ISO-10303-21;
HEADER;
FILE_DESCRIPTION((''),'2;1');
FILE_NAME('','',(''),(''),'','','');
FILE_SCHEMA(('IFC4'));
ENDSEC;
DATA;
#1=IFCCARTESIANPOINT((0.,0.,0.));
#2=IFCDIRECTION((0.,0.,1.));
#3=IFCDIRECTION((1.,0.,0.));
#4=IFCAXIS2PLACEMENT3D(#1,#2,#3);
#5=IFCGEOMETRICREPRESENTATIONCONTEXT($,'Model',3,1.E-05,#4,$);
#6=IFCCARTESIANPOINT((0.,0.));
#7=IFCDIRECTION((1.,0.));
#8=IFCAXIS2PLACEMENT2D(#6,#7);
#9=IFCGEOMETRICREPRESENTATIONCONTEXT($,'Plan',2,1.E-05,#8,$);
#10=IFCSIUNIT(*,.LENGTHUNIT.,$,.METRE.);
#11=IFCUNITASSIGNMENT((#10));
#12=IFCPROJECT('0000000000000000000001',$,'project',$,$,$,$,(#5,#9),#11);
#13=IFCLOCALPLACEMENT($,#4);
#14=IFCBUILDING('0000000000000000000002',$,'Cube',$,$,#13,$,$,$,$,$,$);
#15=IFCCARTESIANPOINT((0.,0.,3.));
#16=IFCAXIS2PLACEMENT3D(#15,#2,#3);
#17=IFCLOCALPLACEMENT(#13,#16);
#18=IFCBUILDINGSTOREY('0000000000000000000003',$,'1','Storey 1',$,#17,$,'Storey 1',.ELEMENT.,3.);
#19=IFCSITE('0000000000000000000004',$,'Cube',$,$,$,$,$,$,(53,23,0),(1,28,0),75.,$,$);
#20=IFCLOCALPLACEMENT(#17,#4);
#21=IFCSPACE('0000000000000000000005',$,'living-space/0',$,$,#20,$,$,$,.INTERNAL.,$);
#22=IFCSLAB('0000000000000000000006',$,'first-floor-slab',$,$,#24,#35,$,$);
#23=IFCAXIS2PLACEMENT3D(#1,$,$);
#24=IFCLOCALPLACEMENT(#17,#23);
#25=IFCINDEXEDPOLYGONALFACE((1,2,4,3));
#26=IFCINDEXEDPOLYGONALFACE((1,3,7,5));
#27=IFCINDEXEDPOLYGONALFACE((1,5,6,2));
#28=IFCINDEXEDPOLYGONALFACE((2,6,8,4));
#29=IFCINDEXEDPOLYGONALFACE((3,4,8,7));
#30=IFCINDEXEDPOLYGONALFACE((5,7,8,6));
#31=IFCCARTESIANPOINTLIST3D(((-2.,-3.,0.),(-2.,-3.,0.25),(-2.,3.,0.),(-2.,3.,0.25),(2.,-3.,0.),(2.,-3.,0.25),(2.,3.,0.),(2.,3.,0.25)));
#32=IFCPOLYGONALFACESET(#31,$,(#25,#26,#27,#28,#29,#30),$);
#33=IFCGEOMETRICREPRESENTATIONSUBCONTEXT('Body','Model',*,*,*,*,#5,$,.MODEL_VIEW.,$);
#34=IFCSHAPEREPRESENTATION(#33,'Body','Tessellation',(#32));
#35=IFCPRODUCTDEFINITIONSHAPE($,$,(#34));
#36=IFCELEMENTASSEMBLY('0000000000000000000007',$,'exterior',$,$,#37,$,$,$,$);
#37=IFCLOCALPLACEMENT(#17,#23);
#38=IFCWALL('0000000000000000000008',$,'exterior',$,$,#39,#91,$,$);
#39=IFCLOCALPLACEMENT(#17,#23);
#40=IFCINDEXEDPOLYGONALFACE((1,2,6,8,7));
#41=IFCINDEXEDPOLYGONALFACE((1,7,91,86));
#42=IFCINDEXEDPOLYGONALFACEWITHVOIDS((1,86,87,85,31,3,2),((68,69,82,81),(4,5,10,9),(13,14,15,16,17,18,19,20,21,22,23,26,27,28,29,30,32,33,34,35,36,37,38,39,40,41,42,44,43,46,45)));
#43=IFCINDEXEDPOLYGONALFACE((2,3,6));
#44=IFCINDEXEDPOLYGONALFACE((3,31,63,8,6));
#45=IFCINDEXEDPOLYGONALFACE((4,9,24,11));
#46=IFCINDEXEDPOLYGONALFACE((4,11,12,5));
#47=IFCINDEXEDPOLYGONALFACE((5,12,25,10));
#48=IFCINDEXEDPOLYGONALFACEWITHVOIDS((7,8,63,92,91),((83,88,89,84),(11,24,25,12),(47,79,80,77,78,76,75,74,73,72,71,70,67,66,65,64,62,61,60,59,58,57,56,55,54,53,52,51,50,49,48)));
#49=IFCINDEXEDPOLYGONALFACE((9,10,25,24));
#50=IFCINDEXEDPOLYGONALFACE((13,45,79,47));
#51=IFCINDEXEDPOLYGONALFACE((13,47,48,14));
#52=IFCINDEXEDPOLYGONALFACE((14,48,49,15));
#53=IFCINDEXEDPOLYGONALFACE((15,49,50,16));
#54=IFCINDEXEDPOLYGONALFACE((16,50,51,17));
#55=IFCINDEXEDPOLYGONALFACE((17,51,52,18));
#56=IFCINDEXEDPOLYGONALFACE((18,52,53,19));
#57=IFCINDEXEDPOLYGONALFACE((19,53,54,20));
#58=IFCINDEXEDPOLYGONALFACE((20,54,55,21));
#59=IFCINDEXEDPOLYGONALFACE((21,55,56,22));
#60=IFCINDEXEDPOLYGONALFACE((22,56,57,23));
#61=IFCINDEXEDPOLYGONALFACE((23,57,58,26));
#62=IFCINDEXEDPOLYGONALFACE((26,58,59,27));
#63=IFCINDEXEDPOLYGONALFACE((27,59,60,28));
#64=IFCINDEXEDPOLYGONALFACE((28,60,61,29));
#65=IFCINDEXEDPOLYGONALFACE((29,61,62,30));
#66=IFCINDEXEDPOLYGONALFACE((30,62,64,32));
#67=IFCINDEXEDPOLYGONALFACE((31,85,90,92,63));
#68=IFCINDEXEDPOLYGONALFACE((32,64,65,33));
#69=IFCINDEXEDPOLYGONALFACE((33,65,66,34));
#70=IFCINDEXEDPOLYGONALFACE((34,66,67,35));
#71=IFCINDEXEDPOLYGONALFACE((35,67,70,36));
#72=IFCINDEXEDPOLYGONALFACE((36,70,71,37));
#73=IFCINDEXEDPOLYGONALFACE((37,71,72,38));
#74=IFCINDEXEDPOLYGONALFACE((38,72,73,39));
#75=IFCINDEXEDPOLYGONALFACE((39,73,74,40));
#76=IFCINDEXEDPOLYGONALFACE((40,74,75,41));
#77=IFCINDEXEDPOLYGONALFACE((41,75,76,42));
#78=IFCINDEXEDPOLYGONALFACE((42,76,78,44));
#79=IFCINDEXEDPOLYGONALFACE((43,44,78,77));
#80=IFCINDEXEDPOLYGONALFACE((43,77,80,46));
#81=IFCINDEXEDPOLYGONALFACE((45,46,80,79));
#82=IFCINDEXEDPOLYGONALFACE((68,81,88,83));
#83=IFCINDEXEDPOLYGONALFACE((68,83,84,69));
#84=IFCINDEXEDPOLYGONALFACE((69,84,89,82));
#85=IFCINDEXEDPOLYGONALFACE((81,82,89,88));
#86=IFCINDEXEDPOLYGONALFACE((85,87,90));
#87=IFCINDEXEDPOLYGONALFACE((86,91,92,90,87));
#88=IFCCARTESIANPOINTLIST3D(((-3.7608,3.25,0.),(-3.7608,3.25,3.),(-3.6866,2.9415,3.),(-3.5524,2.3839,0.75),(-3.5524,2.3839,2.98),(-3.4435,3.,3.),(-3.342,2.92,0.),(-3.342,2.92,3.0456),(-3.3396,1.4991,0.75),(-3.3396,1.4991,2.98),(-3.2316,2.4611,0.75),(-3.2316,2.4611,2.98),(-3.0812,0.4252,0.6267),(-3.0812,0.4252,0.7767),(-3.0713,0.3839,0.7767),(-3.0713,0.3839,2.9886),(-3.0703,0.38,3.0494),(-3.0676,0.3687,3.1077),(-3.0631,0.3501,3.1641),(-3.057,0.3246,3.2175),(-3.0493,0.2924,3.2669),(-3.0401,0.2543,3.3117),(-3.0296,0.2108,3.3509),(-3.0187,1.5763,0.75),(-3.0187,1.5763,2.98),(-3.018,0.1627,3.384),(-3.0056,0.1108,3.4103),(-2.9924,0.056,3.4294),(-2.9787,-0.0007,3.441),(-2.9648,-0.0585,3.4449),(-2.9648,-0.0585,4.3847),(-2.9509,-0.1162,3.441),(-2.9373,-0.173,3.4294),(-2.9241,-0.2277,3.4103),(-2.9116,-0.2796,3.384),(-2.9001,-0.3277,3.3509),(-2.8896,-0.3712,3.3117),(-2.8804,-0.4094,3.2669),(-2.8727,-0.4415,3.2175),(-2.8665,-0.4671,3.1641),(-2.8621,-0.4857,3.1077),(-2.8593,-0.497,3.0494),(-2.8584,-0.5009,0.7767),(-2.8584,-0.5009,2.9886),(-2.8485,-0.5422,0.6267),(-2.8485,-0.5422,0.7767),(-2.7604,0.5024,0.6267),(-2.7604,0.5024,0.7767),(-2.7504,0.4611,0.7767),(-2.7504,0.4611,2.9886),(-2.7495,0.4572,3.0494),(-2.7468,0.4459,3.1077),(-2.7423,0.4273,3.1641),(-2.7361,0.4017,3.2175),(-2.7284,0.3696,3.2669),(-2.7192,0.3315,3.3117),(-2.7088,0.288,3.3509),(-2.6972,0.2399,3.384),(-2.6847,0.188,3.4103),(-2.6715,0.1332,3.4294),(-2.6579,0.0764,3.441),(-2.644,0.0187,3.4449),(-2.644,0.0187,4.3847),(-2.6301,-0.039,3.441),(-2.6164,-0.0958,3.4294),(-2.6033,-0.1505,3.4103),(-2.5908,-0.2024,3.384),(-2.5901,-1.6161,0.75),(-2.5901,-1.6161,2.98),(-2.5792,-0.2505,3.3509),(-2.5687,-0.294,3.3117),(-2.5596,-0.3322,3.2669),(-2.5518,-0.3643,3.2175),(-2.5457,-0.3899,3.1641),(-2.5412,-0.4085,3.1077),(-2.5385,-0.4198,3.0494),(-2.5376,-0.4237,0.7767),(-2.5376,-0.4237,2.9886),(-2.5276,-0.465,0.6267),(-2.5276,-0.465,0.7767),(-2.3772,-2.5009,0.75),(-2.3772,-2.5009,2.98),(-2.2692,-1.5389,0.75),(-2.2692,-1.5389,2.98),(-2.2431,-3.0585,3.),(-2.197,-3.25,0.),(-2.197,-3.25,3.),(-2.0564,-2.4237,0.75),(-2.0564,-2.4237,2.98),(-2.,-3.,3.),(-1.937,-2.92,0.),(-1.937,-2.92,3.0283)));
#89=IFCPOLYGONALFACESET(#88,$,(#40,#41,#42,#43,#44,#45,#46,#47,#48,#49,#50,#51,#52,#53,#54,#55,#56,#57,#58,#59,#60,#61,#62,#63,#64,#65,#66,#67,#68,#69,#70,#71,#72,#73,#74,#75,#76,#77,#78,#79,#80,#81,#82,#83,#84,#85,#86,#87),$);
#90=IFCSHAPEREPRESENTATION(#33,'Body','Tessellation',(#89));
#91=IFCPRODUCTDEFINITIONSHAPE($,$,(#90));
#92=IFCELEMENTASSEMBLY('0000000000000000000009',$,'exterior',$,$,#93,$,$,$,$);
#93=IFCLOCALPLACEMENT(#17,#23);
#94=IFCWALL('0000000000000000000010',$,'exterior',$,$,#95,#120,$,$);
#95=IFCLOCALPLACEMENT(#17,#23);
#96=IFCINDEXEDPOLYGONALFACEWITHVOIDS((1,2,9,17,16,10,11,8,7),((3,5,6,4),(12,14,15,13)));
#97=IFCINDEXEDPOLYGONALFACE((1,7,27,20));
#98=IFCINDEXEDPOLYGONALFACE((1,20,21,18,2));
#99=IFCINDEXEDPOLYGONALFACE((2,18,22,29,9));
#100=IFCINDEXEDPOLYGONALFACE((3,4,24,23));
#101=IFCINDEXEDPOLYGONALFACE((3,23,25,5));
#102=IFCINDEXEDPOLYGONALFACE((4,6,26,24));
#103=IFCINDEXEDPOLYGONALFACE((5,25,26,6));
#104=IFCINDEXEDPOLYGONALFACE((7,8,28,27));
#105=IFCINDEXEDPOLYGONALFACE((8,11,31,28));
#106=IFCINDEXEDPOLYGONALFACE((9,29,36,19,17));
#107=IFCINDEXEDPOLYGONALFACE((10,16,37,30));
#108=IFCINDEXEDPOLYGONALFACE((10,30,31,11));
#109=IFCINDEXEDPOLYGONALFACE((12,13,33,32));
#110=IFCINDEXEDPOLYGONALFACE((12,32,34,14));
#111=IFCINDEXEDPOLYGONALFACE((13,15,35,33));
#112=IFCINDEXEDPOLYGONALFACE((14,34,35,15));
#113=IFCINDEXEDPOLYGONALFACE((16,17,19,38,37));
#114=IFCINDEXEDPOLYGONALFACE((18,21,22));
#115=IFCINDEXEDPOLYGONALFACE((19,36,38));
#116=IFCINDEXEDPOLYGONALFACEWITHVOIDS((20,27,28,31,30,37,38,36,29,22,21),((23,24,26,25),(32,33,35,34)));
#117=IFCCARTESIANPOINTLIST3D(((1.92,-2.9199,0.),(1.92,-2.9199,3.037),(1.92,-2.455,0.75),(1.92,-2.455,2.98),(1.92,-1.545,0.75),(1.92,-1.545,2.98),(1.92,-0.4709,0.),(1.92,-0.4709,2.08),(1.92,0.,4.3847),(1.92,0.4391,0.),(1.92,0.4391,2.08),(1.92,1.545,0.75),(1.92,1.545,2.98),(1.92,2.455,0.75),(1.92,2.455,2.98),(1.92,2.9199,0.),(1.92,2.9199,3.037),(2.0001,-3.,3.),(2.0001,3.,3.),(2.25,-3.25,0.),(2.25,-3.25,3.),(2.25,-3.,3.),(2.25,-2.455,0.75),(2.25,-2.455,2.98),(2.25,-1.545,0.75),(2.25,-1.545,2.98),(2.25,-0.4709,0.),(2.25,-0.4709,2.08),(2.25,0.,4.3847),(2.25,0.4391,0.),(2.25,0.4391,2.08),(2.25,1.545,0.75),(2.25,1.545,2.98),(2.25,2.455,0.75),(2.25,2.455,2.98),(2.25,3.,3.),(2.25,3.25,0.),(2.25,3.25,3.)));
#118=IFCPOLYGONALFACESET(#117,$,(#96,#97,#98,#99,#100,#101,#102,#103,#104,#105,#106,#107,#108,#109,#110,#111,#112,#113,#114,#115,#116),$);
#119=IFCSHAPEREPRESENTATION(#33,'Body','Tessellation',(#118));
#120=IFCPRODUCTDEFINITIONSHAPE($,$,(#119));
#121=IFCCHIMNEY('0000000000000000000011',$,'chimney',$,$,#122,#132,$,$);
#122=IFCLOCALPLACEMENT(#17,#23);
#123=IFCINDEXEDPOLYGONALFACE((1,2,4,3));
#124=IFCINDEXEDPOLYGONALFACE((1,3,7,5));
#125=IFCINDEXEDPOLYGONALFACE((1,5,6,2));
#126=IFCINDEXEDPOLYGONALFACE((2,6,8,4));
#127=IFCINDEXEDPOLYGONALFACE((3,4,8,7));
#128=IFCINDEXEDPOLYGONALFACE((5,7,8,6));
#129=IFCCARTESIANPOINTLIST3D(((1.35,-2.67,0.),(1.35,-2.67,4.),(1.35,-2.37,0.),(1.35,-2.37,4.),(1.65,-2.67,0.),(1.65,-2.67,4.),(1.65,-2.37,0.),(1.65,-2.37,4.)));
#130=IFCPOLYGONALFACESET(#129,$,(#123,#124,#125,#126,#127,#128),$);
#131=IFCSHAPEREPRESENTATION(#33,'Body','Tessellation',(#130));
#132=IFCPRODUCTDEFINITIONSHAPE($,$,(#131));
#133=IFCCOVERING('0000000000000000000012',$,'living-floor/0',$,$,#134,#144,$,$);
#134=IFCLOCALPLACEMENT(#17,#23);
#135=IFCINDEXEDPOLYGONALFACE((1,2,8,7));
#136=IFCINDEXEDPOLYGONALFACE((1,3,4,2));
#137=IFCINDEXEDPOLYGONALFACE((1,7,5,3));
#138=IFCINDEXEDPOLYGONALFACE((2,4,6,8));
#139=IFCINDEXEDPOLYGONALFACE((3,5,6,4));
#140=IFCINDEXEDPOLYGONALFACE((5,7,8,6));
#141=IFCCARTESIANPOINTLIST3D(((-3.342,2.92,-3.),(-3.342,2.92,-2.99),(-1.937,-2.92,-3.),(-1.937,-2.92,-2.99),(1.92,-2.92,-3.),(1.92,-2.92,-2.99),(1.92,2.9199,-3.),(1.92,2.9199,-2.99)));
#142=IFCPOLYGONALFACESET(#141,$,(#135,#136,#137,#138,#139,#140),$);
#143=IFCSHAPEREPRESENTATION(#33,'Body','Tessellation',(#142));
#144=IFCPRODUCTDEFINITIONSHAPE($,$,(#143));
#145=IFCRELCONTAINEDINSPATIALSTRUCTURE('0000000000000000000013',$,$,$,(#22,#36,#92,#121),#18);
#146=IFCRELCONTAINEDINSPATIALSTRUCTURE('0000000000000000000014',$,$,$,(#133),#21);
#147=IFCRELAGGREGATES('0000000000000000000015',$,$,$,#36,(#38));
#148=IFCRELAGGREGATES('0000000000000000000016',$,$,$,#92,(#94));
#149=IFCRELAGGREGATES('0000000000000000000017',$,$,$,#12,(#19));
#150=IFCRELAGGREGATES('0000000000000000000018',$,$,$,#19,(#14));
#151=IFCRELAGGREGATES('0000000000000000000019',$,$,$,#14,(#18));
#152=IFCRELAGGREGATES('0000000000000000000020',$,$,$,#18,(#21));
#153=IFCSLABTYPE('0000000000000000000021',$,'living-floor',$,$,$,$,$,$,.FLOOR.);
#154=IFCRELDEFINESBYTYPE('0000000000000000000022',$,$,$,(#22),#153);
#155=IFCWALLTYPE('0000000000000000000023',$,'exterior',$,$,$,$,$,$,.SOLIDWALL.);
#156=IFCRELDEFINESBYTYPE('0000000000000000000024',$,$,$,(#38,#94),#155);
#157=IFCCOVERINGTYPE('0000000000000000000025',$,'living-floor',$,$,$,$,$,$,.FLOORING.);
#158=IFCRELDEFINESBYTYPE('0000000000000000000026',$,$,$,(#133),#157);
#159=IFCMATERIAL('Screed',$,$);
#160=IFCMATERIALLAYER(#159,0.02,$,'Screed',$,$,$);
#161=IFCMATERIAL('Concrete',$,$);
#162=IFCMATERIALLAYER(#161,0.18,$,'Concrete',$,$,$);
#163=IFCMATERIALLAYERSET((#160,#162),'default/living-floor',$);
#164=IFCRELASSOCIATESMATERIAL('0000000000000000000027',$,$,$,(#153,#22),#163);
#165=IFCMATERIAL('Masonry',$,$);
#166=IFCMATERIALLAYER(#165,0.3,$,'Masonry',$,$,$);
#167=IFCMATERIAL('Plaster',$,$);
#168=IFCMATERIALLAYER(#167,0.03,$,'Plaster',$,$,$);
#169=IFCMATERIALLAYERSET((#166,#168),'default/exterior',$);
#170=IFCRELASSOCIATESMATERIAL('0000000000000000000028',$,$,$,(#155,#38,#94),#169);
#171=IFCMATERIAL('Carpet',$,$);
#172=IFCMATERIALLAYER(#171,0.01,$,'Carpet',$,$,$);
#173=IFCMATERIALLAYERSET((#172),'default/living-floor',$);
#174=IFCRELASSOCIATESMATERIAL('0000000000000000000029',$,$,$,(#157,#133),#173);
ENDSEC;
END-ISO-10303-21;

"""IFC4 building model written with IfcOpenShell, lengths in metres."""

from ifc_helpers import new_model, si_unit, frame, origin, origin_with_axes, origin_2d_with_axis, place, context, subcontext, project, spatial, polyline, line, indexed_curve, outline, extrude, clip, bounded_halfspace, source, transform, mapped, material, layer, layer_set, layer_usage, type_object, element, aggregate, save


model = new_model("IFC4")

# Units and contexts
model_context = context("Model", 3, precision=1e-05, world=origin_with_axes())
plan_context = context("Plan", 2, precision=1e-05, world=origin_2d_with_axis())
body_context_1 = subcontext(model_context, "Body", "Model", "MODEL_VIEW")
ifc_project = project(units=[si_unit("LENGTHUNIT", "METRE")], contexts=[model_context, plan_context])

# Site, building, storey
site = spatial("IfcSite", under=ifc_project, Name="Cube", RefLatitude=(53, 23, 0), RefLongitude=(1, 28, 0), RefElevation=75.0)
building_placement = place(None, origin_with_axes())
building = spatial("IfcBuilding", under=site, at=building_placement, Name="Cube")
storey_placement = place(building_placement, frame((0.0, 0.0, 3.0), z_axis=(0.0, 0.0, 1.0), x_axis=(1.0, 0.0, 0.0)))
storey = spatial("IfcBuildingStorey", under=building, at=storey_placement, Name="1", Description="Storey 1", LongName="Storey 1", CompositionType="ELEMENT", Elevation=3.0)

# Slab
ifc_material_1 = material(Name="Screed")
ifc_layer_1 = layer(ifc_material_1, 0.02, Name="Screed")
ifc_material_2 = material(Name="Concrete")
ifc_layer_2 = layer(ifc_material_2, 0.18, Name="Concrete")
ifc_layer_set_1 = layer_set([ifc_layer_1, ifc_layer_2], Name="default/living-floor")
ifc_layer_usage_1 = layer_usage(ifc_layer_set_1, "AXIS3", "POSITIVE", 0.0)
slab_type = type_object("IfcSlabType", Name="living-floor", PredefinedType="FLOOR", material=ifc_layer_set_1)
slab_placement = place(storey_placement, frame((-2.0, -3.0, 0.0), z_axis=(0.0, 0.0, 1.0), x_axis=(1.0, 0.0, 0.0)))
element("IfcSlab", 1, at=slab_placement, inside=storey, type_object=slab_type, material=ifc_layer_usage_1, Name="first-floor-slab", context=body_context_1, shape_type="SweptSolid", body=[
    extrude(outline(indexed_curve([(0.0, 0.0), (4.0, 0.0), (4.0, 6.0), (0.0, 6.0)])), None, (0.0, 0.0, 1.0), 0.25),
])

# Element assemblies, walls, openings
assembly_1_placement = place(storey_placement, frame((-3.4435, 3.0, 0.0), z_axis=(0.0, 0.0, 1.0), x_axis=(0.233915, -0.972257, 0.0)))
assembly_1 = element("IfcElementAssembly", 2, at=assembly_1_placement, inside=storey, Name="exterior")
ifc_material_3 = material(Name="Masonry")
ifc_layer_3 = layer(ifc_material_3, 0.3, Name="Masonry")
ifc_material_4 = material(Name="Plaster")
ifc_layer_4 = layer(ifc_material_4, 0.03, Name="Plaster")
ifc_layer_set_2 = layer_set([ifc_layer_3, ifc_layer_4], Name="default/exterior")
ifc_layer_usage_2 = layer_usage(ifc_layer_set_2, "AXIS2", "POSITIVE", -0.25)
wall_type = type_object("IfcWallType", Name="exterior", PredefinedType="SOLIDWALL", material=ifc_layer_set_2)
wall_1_placement = place(assembly_1_placement, frame((0.0, 0.0, 0.0), z_axis=(0.0, 0.0, 1.0), x_axis=(1.0, 0.0, 0.0)))
wall_1 = element("IfcWall", 3, at=wall_1_placement, type_object=wall_type, material=ifc_layer_usage_2, Name="exterior", context=body_context_1, shape_type="Clipping", body=[
    clip(clip(clip(clip(extrude(outline(polyline([(0.1015, 0.08), (-0.3173, -0.25), (6.3682, -0.25), (6.1082, 0.08), (0.1015, 0.08)])), origin(), (0.0, 0.0, 1.0), 4.385), bounded_halfspace(frame((6.1712, 0.0, 3.0), z_axis=(0.409415, 0.0, 0.912348), x_axis=(0.0, -1.0, 0.0)), False, origin(), polyline([(6.1712, -1.0), (3.0856, -1.0), (3.0856, 1.0), (6.1712, 1.0), (6.1712, -1.0)]))), bounded_halfspace(frame((6.1712, 0.0, 3.0), z_axis=(0.0, 0.0, 1.0), x_axis=(0.0, 1.0, 0.0)), False, origin(), polyline([(6.1712, 1.0), (7.1712, 1.0), (7.1712, -1.0), (6.1712, -1.0), (6.1712, 1.0)]))), bounded_halfspace(frame((3.0856, 0.0, 4.3847), z_axis=(-0.409415, 0.0, 0.912348), x_axis=(0.0, -1.0, 0.0)), False, origin(), polyline([(3.0856, -1.0), (0.0, -1.0), (0.0, 1.0), (3.0856, 1.0), (3.0856, -1.0)]))), bounded_halfspace(frame((0.0, 0.0, 3.0), z_axis=(0.0, 0.0, 1.0), x_axis=(0.0, -1.0, 0.0)), False, origin(), polyline([(0.0, -1.0), (-1.0, -1.0), (-1.0, 1.0), (0.0, 1.0), (0.0, -1.0)]))),
])
opening_1_placement = place(wall_1_placement, frame((0.5735, -0.25, 0.75), z_axis=(0.0, 0.0, 1.0), x_axis=(1.0, 0.0, 0.0)))
element("IfcOpeningElement", 4, at=opening_1_placement, cuts=wall_1, PredefinedType="OPENING", context=body_context_1, shape_type="SweptSolid", body=[
    extrude(outline(polyline([(0.0, -0.02), (0.91, -0.02), (0.91, 0.35), (0.0, 0.35), (0.0, -0.02)])), origin(), (0.0, 0.0, 1.0), 2.23),
])
opening_2_placement = place(wall_1_placement, frame((2.6306, -0.25, 0.75), z_axis=(0.0, 0.0, 1.0), x_axis=(1.0, 0.0, 0.0)))
element("IfcOpeningElement", 5, at=opening_2_placement, cuts=wall_1, PredefinedType="OPENING", context=body_context_1, shape_type="SweptSolid", body=[
    extrude(outline(polyline([(0.1333, 2.5617), (0.1781, 2.6009), (0.2275, 2.634), (0.2809, 2.6603), (0.3373, 2.6794), (0.3956, 2.691), (0.455, 2.6949), (0.5144, 2.691), (0.5727, 2.6794), (0.6291, 2.6603), (0.6825, 2.634), (0.7319, 2.6009), (0.7767, 2.5617), (0.8159, 2.5169), (0.849, 2.4675), (0.8753, 2.4141), (0.8944, 2.3577), (0.906, 2.2994), (0.91, 2.2386), (0.91, 2.2069), (0.91, 0.0267), (0.9525, 0.0267), (0.9525, -0.1233), (-0.0425, -0.1233), (-0.0425, 0.0267), (0.0, 0.0267), (0.0, 2.2069), (0.0, 2.2386), (0.004, 2.2994), (0.0156, 2.3577), (0.0347, 2.4141), (0.061, 2.4675), (0.0941, 2.5169), (0.1333, 2.5617)])), frame((0.0, -0.02, 0.0), z_axis=(0.0, -1.0, 0.0), x_axis=(1.0, 0.0, 0.0)), (0.0, 0.0, -1.0), 0.37),
])
opening_3_placement = place(wall_1_placement, frame((4.6877, -0.25, 0.75), z_axis=(0.0, 0.0, 1.0), x_axis=(1.0, 0.0, 0.0)))
element("IfcOpeningElement", 6, at=opening_3_placement, cuts=wall_1, PredefinedType="OPENING", context=body_context_1, shape_type="SweptSolid", body=[
    extrude(outline(polyline([(0.0, -0.02), (0.91, -0.02), (0.91, 0.35), (0.0, 0.35), (0.0, -0.02)])), origin(), (0.0, 0.0, 1.0), 2.23),
])
aggregate(assembly_1, [wall_1])
assembly_2_placement = place(storey_placement, frame((2.0, -3.0, 0.0), z_axis=(0.0, 0.0, 1.0), x_axis=(0.0, 1.0, 0.0)))
assembly_2 = element("IfcElementAssembly", 7, at=assembly_2_placement, inside=storey, Name="exterior")
ifc_layer_usage_3 = layer_usage(ifc_layer_set_2, "AXIS2", "POSITIVE", -0.25)
wall_2_placement = place(assembly_2_placement, origin_with_axes())
wall_2 = element("IfcWall", 8, at=wall_2_placement, type_object=wall_type, material=ifc_layer_usage_3, Name="exterior", context=body_context_1, shape_type="Clipping", body=[
    clip(clip(clip(clip(extrude(outline(polyline([(0.0801, 0.08), (-0.25, -0.25), (6.25, -0.25), (5.9199, 0.08), (0.0801, 0.08)])), origin(), (0.0, 0.0, 1.0), 4.385), bounded_halfspace(frame((6.0, 0.0, 3.0), z_axis=(0.419069, 0.0, 0.907954), x_axis=(0.0, -1.0, 0.0)), False, origin(), polyline([(6.0, -1.0), (3.0, -1.0), (3.0, 1.0), (6.0, 1.0), (6.0, -1.0)]))), bounded_halfspace(frame((6.0, 0.0, 3.0), z_axis=(0.0, 0.0, 1.0), x_axis=(0.0, 1.0, 0.0)), False, origin(), polyline([(6.0, 1.0), (7.0, 1.0), (7.0, -1.0), (6.0, -1.0), (6.0, 1.0)]))), bounded_halfspace(frame((3.0, 0.0, 4.3847), z_axis=(-0.419069, 0.0, 0.907954), x_axis=(0.0, -1.0, 0.0)), False, origin(), polyline([(3.0, -1.0), (0.0, -1.0), (0.0, 1.0), (3.0, 1.0), (3.0, -1.0)]))), bounded_halfspace(frame((0.0, 0.0, 3.0), z_axis=(0.0, 0.0, 1.0), x_axis=(0.0, -1.0, 0.0)), False, origin(), polyline([(0.0, -1.0), (-1.0, -1.0), (-1.0, 1.0), (0.0, 1.0), (0.0, -1.0)]))),
])
opening_4_placement = place(wall_2_placement, frame((0.545, -0.25, 0.75), z_axis=(0.0, 0.0, 1.0), x_axis=(1.0, 0.0, 0.0)))
element("IfcOpeningElement", 9, at=opening_4_placement, cuts=wall_2, PredefinedType="OPENING", context=body_context_1, shape_type="SweptSolid", body=[
    extrude(outline(polyline([(0.0, -0.02), (0.91, -0.02), (0.91, 0.35), (0.0, 0.35), (0.0, -0.02)])), origin(), (0.0, 0.0, 1.0), 2.23),
])
opening_5_placement = place(wall_2_placement, frame((4.545, -0.25, 0.75), z_axis=(0.0, 0.0, 1.0), x_axis=(1.0, 0.0, 0.0)))
element("IfcOpeningElement", 10, at=opening_5_placement, cuts=wall_2, PredefinedType="OPENING", context=body_context_1, shape_type="SweptSolid", body=[
    extrude(outline(polyline([(0.0, -0.02), (0.91, -0.02), (0.91, 0.35), (0.0, 0.35), (0.0, -0.02)])), origin(), (0.0, 0.0, 1.0), 2.23),
])
shared_shape_1 = source(origin_with_axes(), body_context_1, "Body", "SweptSolid", [
    extrude(outline(indexed_curve([(0.0, 0.0), (0.91, 0.0), (0.91, 2.08), (0.0, 2.08)], segments=[line(1, 2, 3, 4, 1)])), frame((0.0, -0.6, 0.0), z_axis=(0.0, -1.0, 0.0), x_axis=(1.0, 0.0, 0.0)), (0.0, 0.0, -1.0), 1.2),
])
opening_6_placement = place(wall_2_placement, frame((2.5291, -0.25, 0.0), z_axis=(0.0, 0.0, 1.0), x_axis=(1.0, 0.0, 0.0)))
element("IfcOpeningElement", 11, at=opening_6_placement, cuts=wall_2, PredefinedType="OPENING", context=body_context_1, shape_type="MappedRepresentation", body=[
    mapped(shared_shape_1, transform((0.0, 0.0, 0.0), x_axis=(1.0, 0.0, 0.0), y_axis=(0.0, 1.0, 0.0), z_axis=(0.0, 0.0, 1.0), scale=1.0)),
])
aggregate(assembly_2, [wall_2])

# Chimney
chimney_placement = place(storey_placement, frame((1.35, -2.67, 0.0), z_axis=(0.0, 0.0, 1.0), x_axis=(1.0, 0.0, 0.0)))
element("IfcChimney", 12, at=chimney_placement, inside=storey, Name="chimney", context=body_context_1, shape_type="SweptSolid", body=[
    extrude(outline(indexed_curve([(0.0, 0.0), (0.3, 0.0), (0.3, 0.3), (0.0, 0.3)])), None, (0.0, 0.0, 1.0), 4.0),
])

# Shared definitions
space_placement = place(storey_placement, origin_with_axes())
space = spatial("IfcSpace", under=storey, at=space_placement, Name="living-space/0", PredefinedType="INTERNAL")

# Covering
ifc_material_5 = material(Name="Carpet")
ifc_layer_5 = layer(ifc_material_5, 0.01, Name="Carpet")
ifc_layer_set_3 = layer_set([ifc_layer_5], Name="default/living-floor")
ifc_layer_usage_4 = layer_usage(ifc_layer_set_3, "AXIS3", "POSITIVE", 0.0)
covering_type = type_object("IfcCoveringType", Name="living-floor", PredefinedType="FLOORING", material=ifc_layer_set_3)
covering_placement = place(space_placement, frame((0.0, 0.0, -3.0), z_axis=(0.0, 0.0, 1.0), x_axis=(1.0, 0.0, 0.0)))
element("IfcCovering", 13, at=covering_placement, inside=space, type_object=covering_type, material=ifc_layer_usage_4, Name="living-floor/0", context=body_context_1, shape_type="SweptSolid", body=[
    extrude(outline(polyline([(1.92, 2.9199), (-3.342, 2.92), (-1.937, -2.92), (1.92, -2.92), (1.92, 2.9199)])), origin_with_axes(), (0.0, 0.0, 1.0), 0.01),
])

save(model, "model.ifc")
